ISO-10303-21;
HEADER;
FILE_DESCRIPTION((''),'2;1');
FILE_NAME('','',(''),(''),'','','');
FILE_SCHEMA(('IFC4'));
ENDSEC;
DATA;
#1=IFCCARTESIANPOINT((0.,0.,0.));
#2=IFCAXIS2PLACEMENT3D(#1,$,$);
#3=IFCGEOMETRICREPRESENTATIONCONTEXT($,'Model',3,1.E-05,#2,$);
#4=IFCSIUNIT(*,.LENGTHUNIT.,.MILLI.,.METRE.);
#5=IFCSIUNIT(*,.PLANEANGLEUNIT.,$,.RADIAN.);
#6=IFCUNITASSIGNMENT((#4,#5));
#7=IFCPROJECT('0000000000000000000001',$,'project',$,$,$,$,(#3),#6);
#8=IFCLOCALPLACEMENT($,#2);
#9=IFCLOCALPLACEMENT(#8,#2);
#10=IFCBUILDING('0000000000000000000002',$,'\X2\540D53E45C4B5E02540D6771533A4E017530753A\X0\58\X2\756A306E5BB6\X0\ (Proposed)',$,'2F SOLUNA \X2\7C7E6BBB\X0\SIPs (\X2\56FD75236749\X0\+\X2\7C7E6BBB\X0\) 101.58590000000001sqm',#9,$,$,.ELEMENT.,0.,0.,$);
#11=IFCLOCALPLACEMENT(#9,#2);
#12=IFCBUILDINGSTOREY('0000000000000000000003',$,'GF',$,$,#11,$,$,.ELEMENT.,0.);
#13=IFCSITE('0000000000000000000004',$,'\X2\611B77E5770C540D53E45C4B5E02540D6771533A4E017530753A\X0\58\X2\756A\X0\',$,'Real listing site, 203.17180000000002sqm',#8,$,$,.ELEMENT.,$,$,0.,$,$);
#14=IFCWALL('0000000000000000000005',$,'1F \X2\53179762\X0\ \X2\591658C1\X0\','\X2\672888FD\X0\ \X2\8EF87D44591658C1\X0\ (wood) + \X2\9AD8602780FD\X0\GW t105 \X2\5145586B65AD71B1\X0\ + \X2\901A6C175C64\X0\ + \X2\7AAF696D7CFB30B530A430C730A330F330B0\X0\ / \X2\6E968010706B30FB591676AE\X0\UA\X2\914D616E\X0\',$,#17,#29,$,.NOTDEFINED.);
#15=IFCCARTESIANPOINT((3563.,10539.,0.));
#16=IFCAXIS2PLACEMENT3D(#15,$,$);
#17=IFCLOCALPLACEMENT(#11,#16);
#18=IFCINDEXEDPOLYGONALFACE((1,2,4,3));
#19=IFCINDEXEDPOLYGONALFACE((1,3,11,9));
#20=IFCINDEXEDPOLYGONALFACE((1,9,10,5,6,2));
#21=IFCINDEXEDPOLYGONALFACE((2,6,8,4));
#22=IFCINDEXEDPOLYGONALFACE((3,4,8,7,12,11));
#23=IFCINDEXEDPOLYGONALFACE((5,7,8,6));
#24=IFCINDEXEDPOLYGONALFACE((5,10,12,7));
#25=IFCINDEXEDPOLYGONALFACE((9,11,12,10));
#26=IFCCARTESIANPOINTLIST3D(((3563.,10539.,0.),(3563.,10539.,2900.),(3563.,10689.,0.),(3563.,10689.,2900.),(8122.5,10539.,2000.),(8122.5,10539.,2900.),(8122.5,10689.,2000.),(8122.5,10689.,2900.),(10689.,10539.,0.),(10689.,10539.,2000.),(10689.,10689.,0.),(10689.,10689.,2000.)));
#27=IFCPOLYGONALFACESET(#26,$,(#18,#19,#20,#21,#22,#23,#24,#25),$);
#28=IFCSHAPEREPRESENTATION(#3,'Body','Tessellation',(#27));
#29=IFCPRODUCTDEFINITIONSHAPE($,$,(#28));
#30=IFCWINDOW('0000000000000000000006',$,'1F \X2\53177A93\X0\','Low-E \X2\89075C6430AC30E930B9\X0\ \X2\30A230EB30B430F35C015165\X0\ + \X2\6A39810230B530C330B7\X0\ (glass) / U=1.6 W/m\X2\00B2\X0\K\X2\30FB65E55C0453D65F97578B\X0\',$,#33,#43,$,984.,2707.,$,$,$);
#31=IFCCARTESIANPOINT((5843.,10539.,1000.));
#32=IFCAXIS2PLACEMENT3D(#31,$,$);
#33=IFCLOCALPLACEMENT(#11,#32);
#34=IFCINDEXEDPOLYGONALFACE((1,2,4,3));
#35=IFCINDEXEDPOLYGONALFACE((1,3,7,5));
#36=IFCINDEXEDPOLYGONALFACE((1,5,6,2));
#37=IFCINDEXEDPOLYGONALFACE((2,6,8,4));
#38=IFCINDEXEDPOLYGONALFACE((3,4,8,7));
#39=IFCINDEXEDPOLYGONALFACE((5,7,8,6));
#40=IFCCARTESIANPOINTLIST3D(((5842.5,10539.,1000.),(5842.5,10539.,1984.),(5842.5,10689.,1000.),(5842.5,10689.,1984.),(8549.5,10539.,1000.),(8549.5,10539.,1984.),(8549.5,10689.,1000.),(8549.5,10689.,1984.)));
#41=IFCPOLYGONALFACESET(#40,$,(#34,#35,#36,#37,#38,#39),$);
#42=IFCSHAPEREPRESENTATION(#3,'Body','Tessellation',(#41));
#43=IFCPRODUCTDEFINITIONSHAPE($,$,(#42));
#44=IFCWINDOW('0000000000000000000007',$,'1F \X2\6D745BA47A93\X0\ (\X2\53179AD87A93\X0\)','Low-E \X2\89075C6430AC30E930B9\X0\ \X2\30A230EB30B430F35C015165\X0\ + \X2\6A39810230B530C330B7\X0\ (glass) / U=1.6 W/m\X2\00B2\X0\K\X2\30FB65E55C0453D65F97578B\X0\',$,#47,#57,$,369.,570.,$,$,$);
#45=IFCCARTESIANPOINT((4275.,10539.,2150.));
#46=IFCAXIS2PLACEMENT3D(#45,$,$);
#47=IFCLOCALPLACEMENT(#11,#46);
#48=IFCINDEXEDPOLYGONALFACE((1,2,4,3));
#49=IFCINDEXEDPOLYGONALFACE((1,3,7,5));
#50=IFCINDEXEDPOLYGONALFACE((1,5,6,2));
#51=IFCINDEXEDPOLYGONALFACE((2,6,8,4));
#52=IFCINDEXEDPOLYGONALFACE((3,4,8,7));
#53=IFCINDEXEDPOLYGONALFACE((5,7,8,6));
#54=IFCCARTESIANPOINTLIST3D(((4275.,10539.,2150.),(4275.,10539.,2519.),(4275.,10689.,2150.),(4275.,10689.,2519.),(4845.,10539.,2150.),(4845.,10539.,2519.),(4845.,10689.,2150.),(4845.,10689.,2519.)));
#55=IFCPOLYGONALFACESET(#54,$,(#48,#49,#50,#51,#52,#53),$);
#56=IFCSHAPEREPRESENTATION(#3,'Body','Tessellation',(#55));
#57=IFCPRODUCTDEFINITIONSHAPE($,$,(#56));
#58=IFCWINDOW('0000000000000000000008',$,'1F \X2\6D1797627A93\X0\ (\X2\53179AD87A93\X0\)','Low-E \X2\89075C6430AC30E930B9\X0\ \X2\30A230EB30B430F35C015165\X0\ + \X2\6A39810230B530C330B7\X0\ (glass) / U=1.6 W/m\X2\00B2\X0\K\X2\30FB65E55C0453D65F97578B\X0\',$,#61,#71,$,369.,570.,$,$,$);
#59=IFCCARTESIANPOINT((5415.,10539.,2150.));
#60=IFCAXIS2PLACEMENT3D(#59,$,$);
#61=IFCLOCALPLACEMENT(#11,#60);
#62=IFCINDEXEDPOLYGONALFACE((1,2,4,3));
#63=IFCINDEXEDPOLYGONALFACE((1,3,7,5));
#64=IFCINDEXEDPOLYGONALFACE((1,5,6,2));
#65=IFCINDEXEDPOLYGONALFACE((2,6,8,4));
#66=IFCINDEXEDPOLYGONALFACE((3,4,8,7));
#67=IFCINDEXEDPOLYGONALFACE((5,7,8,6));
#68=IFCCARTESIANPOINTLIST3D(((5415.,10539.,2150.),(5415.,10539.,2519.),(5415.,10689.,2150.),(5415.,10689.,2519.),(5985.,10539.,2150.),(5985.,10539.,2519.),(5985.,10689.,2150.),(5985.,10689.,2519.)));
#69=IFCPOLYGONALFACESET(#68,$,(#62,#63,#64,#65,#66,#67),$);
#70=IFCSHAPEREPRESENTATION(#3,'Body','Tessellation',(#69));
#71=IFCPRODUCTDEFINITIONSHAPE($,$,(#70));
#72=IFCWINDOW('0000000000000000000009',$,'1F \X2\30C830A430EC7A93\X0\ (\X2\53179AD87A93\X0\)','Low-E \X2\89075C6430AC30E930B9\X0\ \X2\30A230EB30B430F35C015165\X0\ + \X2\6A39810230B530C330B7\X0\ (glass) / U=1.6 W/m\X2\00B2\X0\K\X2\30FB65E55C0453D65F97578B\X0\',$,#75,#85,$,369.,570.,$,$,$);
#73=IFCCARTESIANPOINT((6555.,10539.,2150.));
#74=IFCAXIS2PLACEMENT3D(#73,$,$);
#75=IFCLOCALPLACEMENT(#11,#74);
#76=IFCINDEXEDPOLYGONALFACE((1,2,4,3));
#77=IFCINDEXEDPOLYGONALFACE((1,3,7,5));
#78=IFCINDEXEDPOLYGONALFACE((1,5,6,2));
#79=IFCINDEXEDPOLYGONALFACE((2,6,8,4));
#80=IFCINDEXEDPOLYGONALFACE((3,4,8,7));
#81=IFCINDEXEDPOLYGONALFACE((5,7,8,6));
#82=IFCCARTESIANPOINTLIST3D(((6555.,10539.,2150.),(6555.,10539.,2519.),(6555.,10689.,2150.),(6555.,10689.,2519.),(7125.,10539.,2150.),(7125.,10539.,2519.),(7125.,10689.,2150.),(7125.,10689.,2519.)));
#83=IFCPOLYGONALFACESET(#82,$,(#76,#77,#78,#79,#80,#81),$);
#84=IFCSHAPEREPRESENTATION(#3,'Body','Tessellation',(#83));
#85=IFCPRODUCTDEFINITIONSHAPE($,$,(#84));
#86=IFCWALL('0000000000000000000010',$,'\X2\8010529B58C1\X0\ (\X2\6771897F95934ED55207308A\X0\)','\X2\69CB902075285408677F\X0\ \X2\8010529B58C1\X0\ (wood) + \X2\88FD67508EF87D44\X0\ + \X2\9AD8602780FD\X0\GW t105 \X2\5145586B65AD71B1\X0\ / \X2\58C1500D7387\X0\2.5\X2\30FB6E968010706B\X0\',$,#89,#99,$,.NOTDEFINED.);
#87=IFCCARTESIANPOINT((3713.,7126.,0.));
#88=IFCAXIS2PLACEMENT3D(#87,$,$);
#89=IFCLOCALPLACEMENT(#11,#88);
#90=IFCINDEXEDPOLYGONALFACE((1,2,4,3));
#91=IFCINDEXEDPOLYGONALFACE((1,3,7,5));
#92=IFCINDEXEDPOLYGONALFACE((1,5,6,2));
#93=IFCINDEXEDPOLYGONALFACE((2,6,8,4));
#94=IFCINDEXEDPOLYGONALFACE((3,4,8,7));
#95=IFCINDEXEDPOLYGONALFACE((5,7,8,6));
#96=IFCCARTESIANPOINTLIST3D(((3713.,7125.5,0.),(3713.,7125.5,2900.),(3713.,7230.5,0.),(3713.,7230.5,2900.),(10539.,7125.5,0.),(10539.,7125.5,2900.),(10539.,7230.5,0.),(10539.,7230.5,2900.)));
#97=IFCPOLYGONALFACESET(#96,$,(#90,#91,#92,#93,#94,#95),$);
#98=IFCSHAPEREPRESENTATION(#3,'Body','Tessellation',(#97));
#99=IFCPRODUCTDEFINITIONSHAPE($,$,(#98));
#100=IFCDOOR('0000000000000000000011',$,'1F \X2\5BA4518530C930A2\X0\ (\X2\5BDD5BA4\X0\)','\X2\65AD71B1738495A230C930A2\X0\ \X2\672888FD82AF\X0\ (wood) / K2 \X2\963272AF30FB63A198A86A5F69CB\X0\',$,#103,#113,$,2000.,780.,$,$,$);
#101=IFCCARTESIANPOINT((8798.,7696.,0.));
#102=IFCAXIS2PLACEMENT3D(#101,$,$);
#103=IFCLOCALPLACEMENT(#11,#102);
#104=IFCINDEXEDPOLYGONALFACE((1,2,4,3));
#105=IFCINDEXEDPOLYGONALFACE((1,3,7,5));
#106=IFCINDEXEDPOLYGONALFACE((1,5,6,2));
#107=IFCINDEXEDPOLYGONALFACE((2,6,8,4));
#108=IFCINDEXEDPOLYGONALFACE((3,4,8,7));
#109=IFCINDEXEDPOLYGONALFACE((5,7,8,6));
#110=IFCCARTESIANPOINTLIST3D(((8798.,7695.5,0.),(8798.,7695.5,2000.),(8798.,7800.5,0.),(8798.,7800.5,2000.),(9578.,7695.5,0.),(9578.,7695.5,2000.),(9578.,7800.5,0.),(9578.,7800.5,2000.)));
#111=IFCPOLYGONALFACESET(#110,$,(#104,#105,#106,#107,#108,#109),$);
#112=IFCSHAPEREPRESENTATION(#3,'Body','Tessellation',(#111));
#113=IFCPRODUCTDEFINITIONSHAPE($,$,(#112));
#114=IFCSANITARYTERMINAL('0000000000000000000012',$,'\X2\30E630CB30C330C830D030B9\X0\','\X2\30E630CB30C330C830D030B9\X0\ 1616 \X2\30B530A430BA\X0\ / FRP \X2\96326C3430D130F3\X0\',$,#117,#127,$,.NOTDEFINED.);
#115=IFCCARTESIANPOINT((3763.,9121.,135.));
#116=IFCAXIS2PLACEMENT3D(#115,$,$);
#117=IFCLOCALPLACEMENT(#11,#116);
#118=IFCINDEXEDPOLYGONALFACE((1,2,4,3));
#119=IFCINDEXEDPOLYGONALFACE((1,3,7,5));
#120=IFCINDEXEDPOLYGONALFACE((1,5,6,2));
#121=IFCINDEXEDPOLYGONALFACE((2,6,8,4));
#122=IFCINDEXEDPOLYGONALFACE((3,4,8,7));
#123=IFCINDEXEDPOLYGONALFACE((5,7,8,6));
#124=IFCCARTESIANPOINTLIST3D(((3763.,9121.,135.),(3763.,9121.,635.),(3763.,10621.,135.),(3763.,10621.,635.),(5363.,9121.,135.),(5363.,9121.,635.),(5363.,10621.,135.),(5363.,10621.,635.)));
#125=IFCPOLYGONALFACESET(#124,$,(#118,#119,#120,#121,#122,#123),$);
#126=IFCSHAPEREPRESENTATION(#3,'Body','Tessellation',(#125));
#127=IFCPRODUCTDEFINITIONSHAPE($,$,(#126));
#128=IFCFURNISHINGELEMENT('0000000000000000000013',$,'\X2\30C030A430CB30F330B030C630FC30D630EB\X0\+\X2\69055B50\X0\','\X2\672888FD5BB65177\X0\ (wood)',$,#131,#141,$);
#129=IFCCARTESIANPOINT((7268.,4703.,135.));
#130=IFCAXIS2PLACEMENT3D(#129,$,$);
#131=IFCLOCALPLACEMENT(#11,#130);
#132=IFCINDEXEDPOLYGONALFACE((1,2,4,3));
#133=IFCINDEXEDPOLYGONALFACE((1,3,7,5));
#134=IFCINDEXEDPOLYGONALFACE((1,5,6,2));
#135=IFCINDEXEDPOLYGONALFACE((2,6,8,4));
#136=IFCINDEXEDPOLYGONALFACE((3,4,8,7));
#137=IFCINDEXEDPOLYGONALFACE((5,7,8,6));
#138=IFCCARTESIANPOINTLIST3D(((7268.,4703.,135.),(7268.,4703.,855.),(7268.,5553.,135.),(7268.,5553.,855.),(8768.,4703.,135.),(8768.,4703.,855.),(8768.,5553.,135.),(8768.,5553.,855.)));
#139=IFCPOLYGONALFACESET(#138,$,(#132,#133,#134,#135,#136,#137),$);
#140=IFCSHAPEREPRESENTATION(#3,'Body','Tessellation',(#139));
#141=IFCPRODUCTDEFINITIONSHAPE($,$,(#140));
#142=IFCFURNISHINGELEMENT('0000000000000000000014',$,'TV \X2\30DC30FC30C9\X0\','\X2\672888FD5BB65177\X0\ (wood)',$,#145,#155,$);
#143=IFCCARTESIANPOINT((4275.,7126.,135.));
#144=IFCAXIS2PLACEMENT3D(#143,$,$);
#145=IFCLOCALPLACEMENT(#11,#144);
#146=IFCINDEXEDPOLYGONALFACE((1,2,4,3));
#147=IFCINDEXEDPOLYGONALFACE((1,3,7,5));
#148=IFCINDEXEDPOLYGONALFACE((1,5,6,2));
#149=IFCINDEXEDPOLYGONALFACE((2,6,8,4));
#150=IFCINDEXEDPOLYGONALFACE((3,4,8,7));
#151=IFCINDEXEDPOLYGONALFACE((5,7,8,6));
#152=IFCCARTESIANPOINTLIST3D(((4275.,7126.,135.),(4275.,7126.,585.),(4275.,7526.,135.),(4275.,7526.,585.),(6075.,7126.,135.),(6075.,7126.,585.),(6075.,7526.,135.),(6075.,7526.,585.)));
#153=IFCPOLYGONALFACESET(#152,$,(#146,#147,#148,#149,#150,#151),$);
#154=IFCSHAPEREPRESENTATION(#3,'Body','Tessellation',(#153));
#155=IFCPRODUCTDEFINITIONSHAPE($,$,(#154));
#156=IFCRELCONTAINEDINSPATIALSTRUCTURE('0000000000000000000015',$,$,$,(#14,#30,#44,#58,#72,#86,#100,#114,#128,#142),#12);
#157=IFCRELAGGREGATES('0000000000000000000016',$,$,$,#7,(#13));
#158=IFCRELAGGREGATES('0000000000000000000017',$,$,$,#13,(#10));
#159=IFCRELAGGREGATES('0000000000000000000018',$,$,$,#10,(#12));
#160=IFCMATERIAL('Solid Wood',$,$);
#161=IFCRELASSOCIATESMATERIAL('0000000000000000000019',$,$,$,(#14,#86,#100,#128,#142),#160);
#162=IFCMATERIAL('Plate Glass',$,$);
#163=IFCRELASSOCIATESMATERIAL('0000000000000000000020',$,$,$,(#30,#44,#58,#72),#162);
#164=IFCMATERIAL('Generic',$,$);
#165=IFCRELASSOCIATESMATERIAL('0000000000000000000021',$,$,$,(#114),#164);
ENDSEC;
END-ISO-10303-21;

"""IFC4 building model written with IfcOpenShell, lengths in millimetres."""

from ifc_helpers import new_model, si_unit, frame, frame_2d, origin, place, context, project, spatial, rectangle, extrude, material, element, fill, save


model = new_model("IFC4")

# Units and contexts
model_context = context("Model", 3, precision=1e-05, world=origin())
ifc_project = project(units=[si_unit("LENGTHUNIT", "METRE", prefix="MILLI"), si_unit("PLANEANGLEUNIT", "RADIAN")], contexts=[model_context])

# Site, building, storey
site_placement = place(None, origin())
site = spatial("IfcSite", under=ifc_project, at=site_placement, Name="愛知県名古屋市名東区丁田町58番", ObjectType="Real listing site, 203.17180000000002sqm", CompositionType="ELEMENT", RefElevation=0.0)
building_placement = place(site_placement, origin())
building = spatial("IfcBuilding", under=site, at=building_placement, Name="名古屋市名東区丁田町58番の家 (Proposed)", ObjectType="2F SOLUNA 籾殻SIPs (国産杉+籾殻) 101.58590000000001sqm", CompositionType="ELEMENT", ElevationOfRefHeight=0.0, ElevationOfTerrain=0.0)
storey_placement = place(building_placement, origin())
storey = spatial("IfcBuildingStorey", under=building, at=storey_placement, Name="GF", CompositionType="ELEMENT", Elevation=0.0)

# Wall, openings, windows
ifc_material_1 = material(Name="Solid Wood")
wall_1_placement = place(storey_placement, frame((3563.0, 10539.0, 0.0)))
wall_1 = element("IfcWall", 1, at=wall_1_placement, inside=storey, material=ifc_material_1, Name="1F 北面 外壁", Description="木製 軸組外壁 (wood) + 高性能GW t105 充填断熱 + 通気層 + 窯業系サイディング / 準耐火・外皮UA配慮", PredefinedType="NOTDEFINED", context=model_context, shape_type="SweptSolid", body=[
    extrude(rectangle(XDim=7126.0, YDim=150.0, at=frame_2d((3563.0, 75.0))), frame((3563.0, 10539.0, 0.0)), (0.0, 0.0, 1.0), 2900.0),
])
opening_1_placement = place(storey_placement, frame((5843.0, 10539.0, 1000.0)))
opening_1 = element("IfcOpeningElement", 2, at=opening_1_placement, cuts=wall_1, PredefinedType="NOTDEFINED", context=model_context, shape_type="SweptSolid", body=[
    extrude(rectangle(XDim=2707.0, YDim=150.0, at=frame_2d((1353.0, 75.0))), frame((5843.0, 10539.0, 1000.0)), (0.0, 0.0, 1.0), 984.0),
])
opening_2_placement = place(storey_placement, frame((4275.0, 10539.0, 2150.0)))
opening_2 = element("IfcOpeningElement", 3, at=opening_2_placement, cuts=wall_1, PredefinedType="NOTDEFINED", context=model_context, shape_type="SweptSolid", body=[
    extrude(rectangle(XDim=570.0, YDim=150.0, at=frame_2d((285.0, 75.0))), frame((4275.0, 10539.0, 2150.0)), (0.0, 0.0, 1.0), 369.0),
])
opening_3_placement = place(storey_placement, frame((5415.0, 10539.0, 2150.0)))
opening_3 = element("IfcOpeningElement", 4, at=opening_3_placement, cuts=wall_1, PredefinedType="NOTDEFINED", context=model_context, shape_type="SweptSolid", body=[
    extrude(rectangle(XDim=570.0, YDim=150.0, at=frame_2d((285.0, 75.0))), frame((5415.0, 10539.0, 2150.0)), (0.0, 0.0, 1.0), 369.0),
])
opening_4_placement = place(storey_placement, frame((6555.0, 10539.0, 2150.0)))
opening_4 = element("IfcOpeningElement", 5, at=opening_4_placement, cuts=wall_1, PredefinedType="NOTDEFINED", context=model_context, shape_type="SweptSolid", body=[
    extrude(rectangle(XDim=570.0, YDim=150.0, at=frame_2d((285.0, 75.0))), frame((6555.0, 10539.0, 2150.0)), (0.0, 0.0, 1.0), 369.0),
])
ifc_material_2 = material(Name="Plate Glass")
window_1_placement = place(storey_placement, frame((5843.0, 10539.0, 1000.0)))
window_1 = element("IfcWindow", 6, at=window_1_placement, inside=storey, material=ifc_material_2, Name="1F 北窓", Description="Low-E 複層ガラス アルゴン封入 + 樹脂サッシ (glass) / U=1.6 W/m²K・日射取得型", OverallHeight=984.0, OverallWidth=2707.0, context=model_context, shape_type="SweptSolid", body=[
    extrude(rectangle(XDim=2707.0, YDim=150.0, at=frame_2d((1353.0, 75.0))), frame((5843.0, 10539.0, 1000.0)), (0.0, 0.0, 1.0), 984.0),
])
fill(opening_1, window_1)
window_2_placement = place(storey_placement, frame((4275.0, 10539.0, 2150.0)))
window_2 = element("IfcWindow", 7, at=window_2_placement, inside=storey, material=ifc_material_2, Name="1F 浴室窓 (北高窓)", Description="Low-E 複層ガラス アルゴン封入 + 樹脂サッシ (glass) / U=1.6 W/m²K・日射取得型", OverallHeight=369.0, OverallWidth=570.0, context=model_context, shape_type="SweptSolid", body=[
    extrude(rectangle(XDim=570.0, YDim=150.0, at=frame_2d((285.0, 75.0))), frame((4275.0, 10539.0, 2150.0)), (0.0, 0.0, 1.0), 369.0),
])
fill(opening_2, window_2)
window_3_placement = place(storey_placement, frame((5415.0, 10539.0, 2150.0)))
window_3 = element("IfcWindow", 8, at=window_3_placement, inside=storey, material=ifc_material_2, Name="1F 洗面窓 (北高窓)", Description="Low-E 複層ガラス アルゴン封入 + 樹脂サッシ (glass) / U=1.6 W/m²K・日射取得型", OverallHeight=369.0, OverallWidth=570.0, context=model_context, shape_type="SweptSolid", body=[
    extrude(rectangle(XDim=570.0, YDim=150.0, at=frame_2d((285.0, 75.0))), frame((5415.0, 10539.0, 2150.0)), (0.0, 0.0, 1.0), 369.0),
])
fill(opening_3, window_3)
window_4_placement = place(storey_placement, frame((6555.0, 10539.0, 2150.0)))
window_4 = element("IfcWindow", 9, at=window_4_placement, inside=storey, material=ifc_material_2, Name="1F トイレ窓 (北高窓)", Description="Low-E 複層ガラス アルゴン封入 + 樹脂サッシ (glass) / U=1.6 W/m²K・日射取得型", OverallHeight=369.0, OverallWidth=570.0, context=model_context, shape_type="SweptSolid", body=[
    extrude(rectangle(XDim=570.0, YDim=150.0, at=frame_2d((285.0, 75.0))), frame((6555.0, 10539.0, 2150.0)), (0.0, 0.0, 1.0), 369.0),
])
fill(opening_4, window_4)

# Wall
wall_2_placement = place(storey_placement, frame((3713.0, 7126.0, 0.0)))
element("IfcWall", 10, at=wall_2_placement, inside=storey, material=ifc_material_1, Name="耐力壁 (東西間仕切り)", Description="構造用合板 耐力壁 (wood) + 製材軸組 + 高性能GW t105 充填断熱 / 壁倍率2.5・準耐火", PredefinedType="NOTDEFINED", context=model_context, shape_type="SweptSolid", body=[
    extrude(rectangle(XDim=6826.0, YDim=105.0, at=frame_2d((3413.0, 52.0))), frame((3713.0, 7126.0, 0.0)), (0.0, 0.0, 1.0), 2900.0),
])

# Door
door_1_placement = place(storey_placement, frame((8798.0, 7696.0, 0.0)))
element("IfcDoor", 11, at=door_1_placement, inside=storey, material=ifc_material_1, Name="1F 室内ドア (寝室)", Description="断熱玄関ドア 木製芯 (wood) / K2 防犯・採風機構", OverallHeight=2000.0, OverallWidth=780.0, context=model_context, shape_type="SweptSolid", body=[
    extrude(rectangle(XDim=780.0, YDim=105.0, at=frame_2d((390.0, 52.0))), frame((8798.0, 7696.0, 0.0)), (0.0, 0.0, 1.0), 2000.0),
])

# Sanitary terminal
ifc_material_3 = material(Name="Generic")
sanitary_terminal_placement = place(storey_placement, frame((3763.0, 9121.0, 135.0)))
element("IfcSanitaryTerminal", 12, at=sanitary_terminal_placement, inside=storey, material=ifc_material_3, Name="ユニットバス", Description="ユニットバス 1616 サイズ / FRP 防水パン", PredefinedType="NOTDEFINED", context=model_context, shape_type="SweptSolid", body=[
    extrude(rectangle(XDim=1600.0, YDim=1500.0, at=frame_2d((800.0, 750.0))), frame((3763.0, 9121.0, 135.0)), (0.0, 0.0, 1.0), 500.0),
])

# Furnishing elements
furnishing_1_placement = place(storey_placement, frame((7268.0, 4703.0, 135.0)))
element("IfcFurnishingElement", 13, at=furnishing_1_placement, inside=storey, material=ifc_material_1, Name="ダイニングテーブル+椅子", Description="木製家具 (wood)", context=model_context, shape_type="SweptSolid", body=[
    extrude(rectangle(XDim=1500.0, YDim=850.0, at=frame_2d((750.0, 425.0))), frame((7268.0, 4703.0, 135.0)), (0.0, 0.0, 1.0), 720.0),
])
furnishing_2_placement = place(storey_placement, frame((4275.0, 7126.0, 135.0)))
element("IfcFurnishingElement", 14, at=furnishing_2_placement, inside=storey, material=ifc_material_1, Name="TV ボード", Description="木製家具 (wood)", context=model_context, shape_type="SweptSolid", body=[
    extrude(rectangle(XDim=1800.0, YDim=400.0, at=frame_2d((900.0, 200.0))), frame((4275.0, 7126.0, 135.0)), (0.0, 0.0, 1.0), 450.0),
])

save(model, "model.ifc")
